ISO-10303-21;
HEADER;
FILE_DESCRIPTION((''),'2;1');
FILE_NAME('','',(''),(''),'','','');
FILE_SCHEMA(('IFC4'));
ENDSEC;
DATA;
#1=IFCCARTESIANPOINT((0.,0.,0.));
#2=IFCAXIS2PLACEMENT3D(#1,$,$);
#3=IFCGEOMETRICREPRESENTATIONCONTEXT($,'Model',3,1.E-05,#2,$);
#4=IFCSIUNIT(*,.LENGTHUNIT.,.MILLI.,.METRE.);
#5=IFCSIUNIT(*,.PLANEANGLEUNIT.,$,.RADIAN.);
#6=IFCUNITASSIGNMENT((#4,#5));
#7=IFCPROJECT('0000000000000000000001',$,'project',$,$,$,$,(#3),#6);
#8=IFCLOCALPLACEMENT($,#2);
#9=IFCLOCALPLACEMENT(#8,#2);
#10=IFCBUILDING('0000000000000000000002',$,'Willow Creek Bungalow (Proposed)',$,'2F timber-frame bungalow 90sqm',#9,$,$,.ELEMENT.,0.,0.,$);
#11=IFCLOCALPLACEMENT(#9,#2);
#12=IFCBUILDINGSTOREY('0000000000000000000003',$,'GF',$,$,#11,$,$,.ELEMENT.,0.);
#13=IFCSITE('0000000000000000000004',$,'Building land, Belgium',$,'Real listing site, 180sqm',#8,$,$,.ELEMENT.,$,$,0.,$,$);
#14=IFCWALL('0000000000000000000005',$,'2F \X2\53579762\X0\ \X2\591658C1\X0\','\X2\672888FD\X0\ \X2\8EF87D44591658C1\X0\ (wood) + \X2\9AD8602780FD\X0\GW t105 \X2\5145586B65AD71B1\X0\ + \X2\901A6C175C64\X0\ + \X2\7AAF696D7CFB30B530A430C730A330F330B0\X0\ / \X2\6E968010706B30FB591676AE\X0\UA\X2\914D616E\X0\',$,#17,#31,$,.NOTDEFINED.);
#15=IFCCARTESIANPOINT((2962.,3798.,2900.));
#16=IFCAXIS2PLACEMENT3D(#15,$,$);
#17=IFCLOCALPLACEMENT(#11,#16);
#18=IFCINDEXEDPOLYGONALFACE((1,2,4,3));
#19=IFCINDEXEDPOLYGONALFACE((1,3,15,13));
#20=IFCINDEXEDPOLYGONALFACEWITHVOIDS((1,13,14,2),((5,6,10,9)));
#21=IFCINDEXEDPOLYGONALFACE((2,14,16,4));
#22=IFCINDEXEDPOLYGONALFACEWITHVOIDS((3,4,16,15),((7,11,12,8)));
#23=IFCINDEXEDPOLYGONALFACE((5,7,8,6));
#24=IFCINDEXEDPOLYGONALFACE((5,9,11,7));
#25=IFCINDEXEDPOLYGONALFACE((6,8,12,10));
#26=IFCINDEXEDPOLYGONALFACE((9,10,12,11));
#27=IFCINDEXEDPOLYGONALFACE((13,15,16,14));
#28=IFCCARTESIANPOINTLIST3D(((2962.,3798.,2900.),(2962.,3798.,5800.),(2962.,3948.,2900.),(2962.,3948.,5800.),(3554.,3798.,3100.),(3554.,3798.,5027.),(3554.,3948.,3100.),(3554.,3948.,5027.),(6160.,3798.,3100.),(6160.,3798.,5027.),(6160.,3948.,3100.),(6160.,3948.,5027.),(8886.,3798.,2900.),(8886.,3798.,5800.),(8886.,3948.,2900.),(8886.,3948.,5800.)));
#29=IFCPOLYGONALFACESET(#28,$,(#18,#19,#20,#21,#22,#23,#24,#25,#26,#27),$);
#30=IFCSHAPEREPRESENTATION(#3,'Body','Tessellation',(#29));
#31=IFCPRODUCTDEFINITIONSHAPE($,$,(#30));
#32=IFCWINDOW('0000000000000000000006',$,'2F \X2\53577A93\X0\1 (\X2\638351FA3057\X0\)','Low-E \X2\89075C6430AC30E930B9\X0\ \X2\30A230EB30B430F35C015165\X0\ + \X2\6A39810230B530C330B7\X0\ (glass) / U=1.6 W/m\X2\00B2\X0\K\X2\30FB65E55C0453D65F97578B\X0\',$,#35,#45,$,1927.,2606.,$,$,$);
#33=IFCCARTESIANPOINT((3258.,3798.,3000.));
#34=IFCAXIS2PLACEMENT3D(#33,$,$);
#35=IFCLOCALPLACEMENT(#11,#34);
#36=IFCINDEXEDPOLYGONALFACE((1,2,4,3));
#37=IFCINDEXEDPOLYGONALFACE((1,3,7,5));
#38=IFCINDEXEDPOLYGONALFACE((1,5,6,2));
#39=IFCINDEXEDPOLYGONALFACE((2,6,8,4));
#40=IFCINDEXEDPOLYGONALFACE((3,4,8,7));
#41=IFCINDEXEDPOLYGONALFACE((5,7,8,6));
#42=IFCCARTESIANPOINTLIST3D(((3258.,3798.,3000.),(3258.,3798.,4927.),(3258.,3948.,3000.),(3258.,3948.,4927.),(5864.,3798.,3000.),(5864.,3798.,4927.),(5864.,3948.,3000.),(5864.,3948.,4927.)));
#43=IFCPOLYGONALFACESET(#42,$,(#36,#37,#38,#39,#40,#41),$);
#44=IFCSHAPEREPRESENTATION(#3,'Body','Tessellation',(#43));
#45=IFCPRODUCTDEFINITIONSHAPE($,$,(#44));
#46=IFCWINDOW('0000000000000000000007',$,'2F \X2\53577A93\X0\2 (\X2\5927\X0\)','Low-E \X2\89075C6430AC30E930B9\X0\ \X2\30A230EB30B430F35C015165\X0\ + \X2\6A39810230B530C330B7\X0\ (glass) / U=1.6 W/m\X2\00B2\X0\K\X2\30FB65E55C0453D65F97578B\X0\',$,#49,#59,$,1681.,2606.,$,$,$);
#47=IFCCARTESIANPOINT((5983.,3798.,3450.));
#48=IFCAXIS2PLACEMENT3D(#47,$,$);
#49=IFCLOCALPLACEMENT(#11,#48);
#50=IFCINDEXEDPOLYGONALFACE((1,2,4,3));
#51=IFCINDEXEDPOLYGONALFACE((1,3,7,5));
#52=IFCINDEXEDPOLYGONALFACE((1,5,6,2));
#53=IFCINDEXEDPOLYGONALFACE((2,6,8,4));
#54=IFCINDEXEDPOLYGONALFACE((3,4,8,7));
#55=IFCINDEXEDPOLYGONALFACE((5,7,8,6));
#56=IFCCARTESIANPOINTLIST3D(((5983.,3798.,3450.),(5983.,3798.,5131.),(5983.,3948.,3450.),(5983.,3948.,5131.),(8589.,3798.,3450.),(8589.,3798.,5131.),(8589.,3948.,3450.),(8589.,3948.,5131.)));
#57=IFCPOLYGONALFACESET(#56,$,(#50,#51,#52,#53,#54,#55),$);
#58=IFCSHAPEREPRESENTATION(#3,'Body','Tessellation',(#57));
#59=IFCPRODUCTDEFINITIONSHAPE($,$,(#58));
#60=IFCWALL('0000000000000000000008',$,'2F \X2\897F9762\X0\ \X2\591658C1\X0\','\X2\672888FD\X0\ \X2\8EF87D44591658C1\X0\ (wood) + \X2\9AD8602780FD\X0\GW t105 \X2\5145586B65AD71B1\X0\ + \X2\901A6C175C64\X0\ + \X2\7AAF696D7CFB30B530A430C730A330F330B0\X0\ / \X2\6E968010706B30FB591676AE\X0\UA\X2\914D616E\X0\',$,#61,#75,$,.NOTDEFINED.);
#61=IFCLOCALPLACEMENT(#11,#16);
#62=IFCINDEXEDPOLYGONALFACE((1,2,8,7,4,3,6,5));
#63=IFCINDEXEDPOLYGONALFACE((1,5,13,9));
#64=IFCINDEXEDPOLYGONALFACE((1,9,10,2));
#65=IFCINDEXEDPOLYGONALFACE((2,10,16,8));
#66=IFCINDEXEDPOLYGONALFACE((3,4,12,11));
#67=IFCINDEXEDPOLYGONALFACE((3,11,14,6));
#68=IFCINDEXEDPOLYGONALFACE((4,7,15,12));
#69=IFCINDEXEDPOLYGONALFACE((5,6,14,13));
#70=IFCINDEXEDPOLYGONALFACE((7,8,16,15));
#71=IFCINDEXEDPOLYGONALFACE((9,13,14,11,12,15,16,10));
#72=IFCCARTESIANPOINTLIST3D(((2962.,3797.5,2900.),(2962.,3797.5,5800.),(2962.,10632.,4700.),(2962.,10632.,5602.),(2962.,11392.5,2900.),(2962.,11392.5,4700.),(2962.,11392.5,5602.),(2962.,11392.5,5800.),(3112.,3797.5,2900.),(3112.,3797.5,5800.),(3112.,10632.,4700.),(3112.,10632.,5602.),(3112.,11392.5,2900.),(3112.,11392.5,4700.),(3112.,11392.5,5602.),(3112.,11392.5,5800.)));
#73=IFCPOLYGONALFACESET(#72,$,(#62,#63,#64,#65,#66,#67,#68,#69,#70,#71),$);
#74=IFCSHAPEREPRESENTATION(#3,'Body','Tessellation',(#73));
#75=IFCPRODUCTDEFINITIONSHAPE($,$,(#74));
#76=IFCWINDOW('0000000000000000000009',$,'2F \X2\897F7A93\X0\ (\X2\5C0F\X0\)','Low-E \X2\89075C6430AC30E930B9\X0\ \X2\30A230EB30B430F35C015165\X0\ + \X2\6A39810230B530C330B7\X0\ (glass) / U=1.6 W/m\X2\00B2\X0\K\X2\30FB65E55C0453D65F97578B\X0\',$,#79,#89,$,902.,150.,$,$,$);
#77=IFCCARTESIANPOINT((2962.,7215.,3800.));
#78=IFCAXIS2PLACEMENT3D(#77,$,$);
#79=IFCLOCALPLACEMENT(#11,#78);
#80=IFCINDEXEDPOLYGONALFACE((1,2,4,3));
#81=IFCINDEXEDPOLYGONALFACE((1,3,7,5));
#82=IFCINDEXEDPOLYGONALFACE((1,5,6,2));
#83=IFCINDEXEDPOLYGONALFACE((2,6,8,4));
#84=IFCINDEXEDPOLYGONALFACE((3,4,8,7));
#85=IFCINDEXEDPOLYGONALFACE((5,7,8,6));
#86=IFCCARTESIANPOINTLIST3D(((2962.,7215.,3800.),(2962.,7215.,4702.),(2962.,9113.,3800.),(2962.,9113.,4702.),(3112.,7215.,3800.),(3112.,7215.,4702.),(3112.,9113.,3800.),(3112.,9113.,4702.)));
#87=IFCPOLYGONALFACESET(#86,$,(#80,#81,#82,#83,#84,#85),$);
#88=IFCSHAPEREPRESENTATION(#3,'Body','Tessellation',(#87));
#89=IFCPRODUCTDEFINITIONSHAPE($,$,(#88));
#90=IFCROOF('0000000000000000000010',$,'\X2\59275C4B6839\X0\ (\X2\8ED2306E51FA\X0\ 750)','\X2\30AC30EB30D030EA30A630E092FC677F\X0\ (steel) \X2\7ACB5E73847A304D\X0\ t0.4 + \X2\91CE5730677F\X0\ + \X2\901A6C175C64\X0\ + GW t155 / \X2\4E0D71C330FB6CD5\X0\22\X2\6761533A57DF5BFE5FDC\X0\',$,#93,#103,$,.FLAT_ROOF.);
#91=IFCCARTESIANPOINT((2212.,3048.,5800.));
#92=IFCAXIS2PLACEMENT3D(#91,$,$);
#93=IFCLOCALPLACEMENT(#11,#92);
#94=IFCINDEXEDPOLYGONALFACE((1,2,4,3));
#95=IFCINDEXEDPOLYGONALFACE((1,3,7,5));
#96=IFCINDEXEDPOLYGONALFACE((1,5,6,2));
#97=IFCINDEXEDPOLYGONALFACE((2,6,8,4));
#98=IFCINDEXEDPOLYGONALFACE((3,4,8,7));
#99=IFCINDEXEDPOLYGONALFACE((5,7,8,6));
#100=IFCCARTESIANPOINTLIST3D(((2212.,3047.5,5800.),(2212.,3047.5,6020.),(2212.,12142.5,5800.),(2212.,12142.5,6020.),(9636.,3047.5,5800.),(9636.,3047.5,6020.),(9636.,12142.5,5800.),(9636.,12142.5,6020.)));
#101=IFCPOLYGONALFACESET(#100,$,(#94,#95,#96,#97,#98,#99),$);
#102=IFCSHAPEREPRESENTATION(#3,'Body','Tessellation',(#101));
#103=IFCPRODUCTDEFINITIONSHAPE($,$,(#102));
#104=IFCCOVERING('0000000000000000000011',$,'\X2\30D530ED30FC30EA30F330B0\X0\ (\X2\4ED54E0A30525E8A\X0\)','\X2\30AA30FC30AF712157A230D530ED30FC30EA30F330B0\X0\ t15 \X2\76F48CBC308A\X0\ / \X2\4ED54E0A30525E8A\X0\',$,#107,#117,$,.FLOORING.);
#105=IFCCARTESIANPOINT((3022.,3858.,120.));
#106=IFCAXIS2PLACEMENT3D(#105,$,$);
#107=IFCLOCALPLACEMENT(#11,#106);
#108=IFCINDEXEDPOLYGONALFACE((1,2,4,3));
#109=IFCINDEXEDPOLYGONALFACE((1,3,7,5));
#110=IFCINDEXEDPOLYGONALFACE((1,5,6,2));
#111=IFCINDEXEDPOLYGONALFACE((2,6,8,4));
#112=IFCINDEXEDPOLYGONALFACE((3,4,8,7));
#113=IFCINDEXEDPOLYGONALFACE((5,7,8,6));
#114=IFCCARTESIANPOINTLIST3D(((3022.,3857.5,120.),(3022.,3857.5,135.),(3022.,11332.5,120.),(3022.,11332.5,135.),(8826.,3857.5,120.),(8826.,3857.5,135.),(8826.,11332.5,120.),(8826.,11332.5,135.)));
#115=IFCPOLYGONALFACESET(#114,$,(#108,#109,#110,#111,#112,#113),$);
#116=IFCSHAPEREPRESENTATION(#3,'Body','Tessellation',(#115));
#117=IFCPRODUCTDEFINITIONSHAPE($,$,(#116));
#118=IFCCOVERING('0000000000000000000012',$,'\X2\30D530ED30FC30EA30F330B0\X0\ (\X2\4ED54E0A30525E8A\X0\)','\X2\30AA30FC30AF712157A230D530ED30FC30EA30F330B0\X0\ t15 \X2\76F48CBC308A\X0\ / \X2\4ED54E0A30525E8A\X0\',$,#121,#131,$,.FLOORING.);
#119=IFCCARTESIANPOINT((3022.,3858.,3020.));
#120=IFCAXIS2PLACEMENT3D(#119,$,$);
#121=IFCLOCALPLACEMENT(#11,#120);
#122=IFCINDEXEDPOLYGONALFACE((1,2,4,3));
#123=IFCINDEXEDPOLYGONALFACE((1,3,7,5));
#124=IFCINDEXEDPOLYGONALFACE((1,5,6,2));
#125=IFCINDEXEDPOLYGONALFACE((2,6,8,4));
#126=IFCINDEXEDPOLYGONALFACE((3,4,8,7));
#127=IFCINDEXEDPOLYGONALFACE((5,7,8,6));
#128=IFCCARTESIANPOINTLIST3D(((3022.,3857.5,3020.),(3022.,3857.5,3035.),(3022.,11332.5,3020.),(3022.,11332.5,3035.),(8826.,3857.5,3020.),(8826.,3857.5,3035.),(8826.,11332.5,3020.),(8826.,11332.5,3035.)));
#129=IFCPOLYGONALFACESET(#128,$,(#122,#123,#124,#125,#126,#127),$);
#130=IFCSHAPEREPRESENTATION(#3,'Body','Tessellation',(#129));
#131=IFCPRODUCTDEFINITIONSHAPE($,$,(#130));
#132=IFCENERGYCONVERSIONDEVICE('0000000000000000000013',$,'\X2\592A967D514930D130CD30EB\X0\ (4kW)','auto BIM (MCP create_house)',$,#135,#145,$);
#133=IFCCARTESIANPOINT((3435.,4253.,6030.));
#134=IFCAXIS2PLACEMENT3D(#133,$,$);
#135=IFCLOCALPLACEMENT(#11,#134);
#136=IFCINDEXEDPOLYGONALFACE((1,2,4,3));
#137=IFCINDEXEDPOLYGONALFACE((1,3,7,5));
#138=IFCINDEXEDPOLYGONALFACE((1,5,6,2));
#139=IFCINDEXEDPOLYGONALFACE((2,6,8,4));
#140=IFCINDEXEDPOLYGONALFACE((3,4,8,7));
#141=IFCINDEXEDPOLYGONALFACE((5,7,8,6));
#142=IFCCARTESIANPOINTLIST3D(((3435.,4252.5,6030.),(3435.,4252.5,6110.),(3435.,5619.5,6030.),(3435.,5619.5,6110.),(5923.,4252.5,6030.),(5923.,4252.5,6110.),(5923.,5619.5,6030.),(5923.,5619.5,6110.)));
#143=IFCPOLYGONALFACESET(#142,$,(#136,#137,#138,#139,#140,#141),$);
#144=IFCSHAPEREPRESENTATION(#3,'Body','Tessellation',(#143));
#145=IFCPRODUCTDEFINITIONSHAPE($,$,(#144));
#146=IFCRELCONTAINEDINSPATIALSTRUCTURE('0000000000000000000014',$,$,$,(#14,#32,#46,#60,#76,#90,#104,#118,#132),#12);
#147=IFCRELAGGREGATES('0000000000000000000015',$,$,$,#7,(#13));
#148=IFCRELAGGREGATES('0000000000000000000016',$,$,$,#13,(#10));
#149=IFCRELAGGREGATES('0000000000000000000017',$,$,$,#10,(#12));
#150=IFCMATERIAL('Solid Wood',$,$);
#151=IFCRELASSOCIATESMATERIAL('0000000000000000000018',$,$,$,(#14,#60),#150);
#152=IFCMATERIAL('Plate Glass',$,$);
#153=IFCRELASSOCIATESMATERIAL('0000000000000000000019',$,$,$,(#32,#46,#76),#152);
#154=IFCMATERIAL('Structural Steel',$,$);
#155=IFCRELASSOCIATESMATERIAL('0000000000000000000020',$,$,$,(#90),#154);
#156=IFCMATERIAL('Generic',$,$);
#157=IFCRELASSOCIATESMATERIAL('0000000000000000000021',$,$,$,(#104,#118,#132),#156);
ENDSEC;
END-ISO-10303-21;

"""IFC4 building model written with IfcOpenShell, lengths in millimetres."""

from ifc_helpers import new_model, si_unit, frame, frame_2d, origin, place, context, project, spatial, rectangle, extrude, material, element, fill, save


model = new_model("IFC4")

# Units and contexts
model_context = context("Model", 3, precision=1e-05, world=origin())
ifc_project = project(units=[si_unit("LENGTHUNIT", "METRE", prefix="MILLI"), si_unit("PLANEANGLEUNIT", "RADIAN")], contexts=[model_context])

# Site, building, storey
site_placement = place(None, origin())
site = spatial("IfcSite", under=ifc_project, at=site_placement, Name="Building land, Belgium", ObjectType="Real listing site, 180sqm", CompositionType="ELEMENT", RefElevation=0.0)
building_placement = place(site_placement, origin())
building = spatial("IfcBuilding", under=site, at=building_placement, Name="Willow Creek Bungalow (Proposed)", ObjectType="2F timber-frame bungalow 90sqm", CompositionType="ELEMENT", ElevationOfRefHeight=0.0, ElevationOfTerrain=0.0)
storey_placement = place(building_placement, origin())
storey = spatial("IfcBuildingStorey", under=building, at=storey_placement, Name="GF", CompositionType="ELEMENT", Elevation=0.0)

# Shared definitions
ifc_material_1 = material(Name="Solid Wood")

# Shared definitions
ifc_material_2 = material(Name="Plate Glass")

# Wall, openings, windows
wall_1_placement = place(storey_placement, frame((2962.0, 3798.0, 2900.0)))
wall_1 = element("IfcWall", 1, at=wall_1_placement, inside=storey, material=ifc_material_1, Name="2F 南面 外壁", Description="木製 軸組外壁 (wood) + 高性能GW t105 充填断熱 + 通気層 + 窯業系サイディング / 準耐火・外皮UA配慮", PredefinedType="NOTDEFINED", context=model_context, shape_type="SweptSolid", body=[
    extrude(rectangle(XDim=5924.0, YDim=150.0, at=frame_2d((2962.0, 75.0))), frame((2962.0, 3798.0, 2900.0)), (0.0, 0.0, 1.0), 2900.0),
])
opening_1_placement = place(storey_placement, frame((3258.0, 3798.0, 3000.0)))
opening_1 = element("IfcOpeningElement", 2, at=opening_1_placement, cuts=wall_1, PredefinedType="NOTDEFINED", context=model_context, shape_type="SweptSolid", body=[
    extrude(rectangle(XDim=2606.0, YDim=150.0, at=frame_2d((1303.0, 75.0))), frame((3258.0, 3798.0, 3000.0)), (0.0, 0.0, 1.0), 1927.0),
])
opening_2_placement = place(storey_placement, frame((5983.0, 3798.0, 3450.0)))
opening_2 = element("IfcOpeningElement", 3, at=opening_2_placement, cuts=wall_1, PredefinedType="NOTDEFINED", context=model_context, shape_type="SweptSolid", body=[
    extrude(rectangle(XDim=2606.0, YDim=150.0, at=frame_2d((1303.0, 75.0))), frame((5983.0, 3798.0, 3450.0)), (0.0, 0.0, 1.0), 1681.0),
])
window_1_placement = place(storey_placement, frame((3258.0, 3798.0, 3000.0)))
window_1 = element("IfcWindow", 4, at=window_1_placement, inside=storey, material=ifc_material_2, Name="2F 南窓1 (掃出し)", Description="Low-E 複層ガラス アルゴン封入 + 樹脂サッシ (glass) / U=1.6 W/m²K・日射取得型", OverallHeight=1927.0, OverallWidth=2606.0, context=model_context, shape_type="SweptSolid", body=[
    extrude(rectangle(XDim=2606.0, YDim=150.0, at=frame_2d((1303.0, 75.0))), frame((3258.0, 3798.0, 3000.0)), (0.0, 0.0, 1.0), 1927.0),
])
fill(opening_1, window_1)
window_2_placement = place(storey_placement, frame((5983.0, 3798.0, 3450.0)))
window_2 = element("IfcWindow", 5, at=window_2_placement, inside=storey, material=ifc_material_2, Name="2F 南窓2 (大)", Description="Low-E 複層ガラス アルゴン封入 + 樹脂サッシ (glass) / U=1.6 W/m²K・日射取得型", OverallHeight=1681.0, OverallWidth=2606.0, context=model_context, shape_type="SweptSolid", body=[
    extrude(rectangle(XDim=2606.0, YDim=150.0, at=frame_2d((1303.0, 75.0))), frame((5983.0, 3798.0, 3450.0)), (0.0, 0.0, 1.0), 1681.0),
])
fill(opening_2, window_2)

# Wall, opening, window
wall_2_placement = place(storey_placement, frame((2962.0, 3798.0, 2900.0)))
wall_2 = element("IfcWall", 6, at=wall_2_placement, inside=storey, material=ifc_material_1, Name="2F 西面 外壁", Description="木製 軸組外壁 (wood) + 高性能GW t105 充填断熱 + 通気層 + 窯業系サイディング / 準耐火・外皮UA配慮", PredefinedType="NOTDEFINED", context=model_context, shape_type="SweptSolid", body=[
    extrude(rectangle(XDim=150.0, YDim=7595.0, at=frame_2d((75.0, 3797.0))), frame((2962.0, 3798.0, 2900.0)), (0.0, 0.0, 1.0), 2900.0),
])
opening_3_placement = place(storey_placement, frame((2962.0, 7215.0, 3800.0)))
opening_3 = element("IfcOpeningElement", 7, at=opening_3_placement, cuts=wall_2, PredefinedType="NOTDEFINED", context=model_context, shape_type="SweptSolid", body=[
    extrude(rectangle(XDim=150.0, YDim=1898.0, at=frame_2d((75.0, 949.0))), frame((2962.0, 7215.0, 3800.0)), (0.0, 0.0, 1.0), 902.0),
])
window_3_placement = place(storey_placement, frame((2962.0, 7215.0, 3800.0)))
window_3 = element("IfcWindow", 8, at=window_3_placement, inside=storey, material=ifc_material_2, Name="2F 西窓 (小)", Description="Low-E 複層ガラス アルゴン封入 + 樹脂サッシ (glass) / U=1.6 W/m²K・日射取得型", OverallHeight=902.0, OverallWidth=150.0, context=model_context, shape_type="SweptSolid", body=[
    extrude(rectangle(XDim=150.0, YDim=1898.0, at=frame_2d((75.0, 949.0))), frame((2962.0, 7215.0, 3800.0)), (0.0, 0.0, 1.0), 902.0),
])
fill(opening_3, window_3)

# Roof
ifc_material_3 = material(Name="Structural Steel")
roof_placement = place(storey_placement, frame((2212.0, 3048.0, 5800.0)))
element("IfcRoof", 9, at=roof_placement, inside=storey, material=ifc_material_3, Name="大屋根 (軒の出 750)", Description="ガルバリウム鋼板 (steel) 立平葺き t0.4 + 野地板 + 通気層 + GW t155 / 不燃・法22条区域対応", PredefinedType="FLAT_ROOF", context=model_context, shape_type="SweptSolid", body=[
    extrude(rectangle(XDim=7424.0, YDim=9095.0, at=frame_2d((3712.0, 4547.0))), frame((2212.0, 3048.0, 5800.0)), (0.0, 0.0, 1.0), 220.0),
])

# Coverings
ifc_material_4 = material(Name="Generic")
covering_1_placement = place(storey_placement, frame((3022.0, 3858.0, 120.0)))
element("IfcCovering", 10, at=covering_1_placement, inside=storey, material=ifc_material_4, Name="フローリング (仕上げ床)", Description="オーク無垢フローリング t15 直貼り / 仕上げ床", PredefinedType="FLOORING", context=model_context, shape_type="SweptSolid", body=[
    extrude(rectangle(XDim=5804.0, YDim=7475.0, at=frame_2d((2902.0, 3737.0))), frame((3022.0, 3858.0, 120.0)), (0.0, 0.0, 1.0), 15.0),
])
covering_2_placement = place(storey_placement, frame((3022.0, 3858.0, 3020.0)))
element("IfcCovering", 11, at=covering_2_placement, inside=storey, material=ifc_material_4, Name="フローリング (仕上げ床)", Description="オーク無垢フローリング t15 直貼り / 仕上げ床", PredefinedType="FLOORING", context=model_context, shape_type="SweptSolid", body=[
    extrude(rectangle(XDim=5804.0, YDim=7475.0, at=frame_2d((2902.0, 3737.0))), frame((3022.0, 3858.0, 3020.0)), (0.0, 0.0, 1.0), 15.0),
])

# Energy conversion device
energy_conversion_device_placement = place(storey_placement, frame((3435.0, 4253.0, 6030.0)))
element("IfcEnergyConversionDevice", 12, at=energy_conversion_device_placement, inside=storey, material=ifc_material_4, Name="太陽光パネル (4kW)", Description="auto BIM (MCP create_house)", context=model_context, shape_type="SweptSolid", body=[
    extrude(rectangle(XDim=2488.0, YDim=1367.0, at=frame_2d((1244.0, 683.0))), frame((3435.0, 4253.0, 6030.0)), (0.0, 0.0, 1.0), 80.0),
])

save(model, "model.ifc")
